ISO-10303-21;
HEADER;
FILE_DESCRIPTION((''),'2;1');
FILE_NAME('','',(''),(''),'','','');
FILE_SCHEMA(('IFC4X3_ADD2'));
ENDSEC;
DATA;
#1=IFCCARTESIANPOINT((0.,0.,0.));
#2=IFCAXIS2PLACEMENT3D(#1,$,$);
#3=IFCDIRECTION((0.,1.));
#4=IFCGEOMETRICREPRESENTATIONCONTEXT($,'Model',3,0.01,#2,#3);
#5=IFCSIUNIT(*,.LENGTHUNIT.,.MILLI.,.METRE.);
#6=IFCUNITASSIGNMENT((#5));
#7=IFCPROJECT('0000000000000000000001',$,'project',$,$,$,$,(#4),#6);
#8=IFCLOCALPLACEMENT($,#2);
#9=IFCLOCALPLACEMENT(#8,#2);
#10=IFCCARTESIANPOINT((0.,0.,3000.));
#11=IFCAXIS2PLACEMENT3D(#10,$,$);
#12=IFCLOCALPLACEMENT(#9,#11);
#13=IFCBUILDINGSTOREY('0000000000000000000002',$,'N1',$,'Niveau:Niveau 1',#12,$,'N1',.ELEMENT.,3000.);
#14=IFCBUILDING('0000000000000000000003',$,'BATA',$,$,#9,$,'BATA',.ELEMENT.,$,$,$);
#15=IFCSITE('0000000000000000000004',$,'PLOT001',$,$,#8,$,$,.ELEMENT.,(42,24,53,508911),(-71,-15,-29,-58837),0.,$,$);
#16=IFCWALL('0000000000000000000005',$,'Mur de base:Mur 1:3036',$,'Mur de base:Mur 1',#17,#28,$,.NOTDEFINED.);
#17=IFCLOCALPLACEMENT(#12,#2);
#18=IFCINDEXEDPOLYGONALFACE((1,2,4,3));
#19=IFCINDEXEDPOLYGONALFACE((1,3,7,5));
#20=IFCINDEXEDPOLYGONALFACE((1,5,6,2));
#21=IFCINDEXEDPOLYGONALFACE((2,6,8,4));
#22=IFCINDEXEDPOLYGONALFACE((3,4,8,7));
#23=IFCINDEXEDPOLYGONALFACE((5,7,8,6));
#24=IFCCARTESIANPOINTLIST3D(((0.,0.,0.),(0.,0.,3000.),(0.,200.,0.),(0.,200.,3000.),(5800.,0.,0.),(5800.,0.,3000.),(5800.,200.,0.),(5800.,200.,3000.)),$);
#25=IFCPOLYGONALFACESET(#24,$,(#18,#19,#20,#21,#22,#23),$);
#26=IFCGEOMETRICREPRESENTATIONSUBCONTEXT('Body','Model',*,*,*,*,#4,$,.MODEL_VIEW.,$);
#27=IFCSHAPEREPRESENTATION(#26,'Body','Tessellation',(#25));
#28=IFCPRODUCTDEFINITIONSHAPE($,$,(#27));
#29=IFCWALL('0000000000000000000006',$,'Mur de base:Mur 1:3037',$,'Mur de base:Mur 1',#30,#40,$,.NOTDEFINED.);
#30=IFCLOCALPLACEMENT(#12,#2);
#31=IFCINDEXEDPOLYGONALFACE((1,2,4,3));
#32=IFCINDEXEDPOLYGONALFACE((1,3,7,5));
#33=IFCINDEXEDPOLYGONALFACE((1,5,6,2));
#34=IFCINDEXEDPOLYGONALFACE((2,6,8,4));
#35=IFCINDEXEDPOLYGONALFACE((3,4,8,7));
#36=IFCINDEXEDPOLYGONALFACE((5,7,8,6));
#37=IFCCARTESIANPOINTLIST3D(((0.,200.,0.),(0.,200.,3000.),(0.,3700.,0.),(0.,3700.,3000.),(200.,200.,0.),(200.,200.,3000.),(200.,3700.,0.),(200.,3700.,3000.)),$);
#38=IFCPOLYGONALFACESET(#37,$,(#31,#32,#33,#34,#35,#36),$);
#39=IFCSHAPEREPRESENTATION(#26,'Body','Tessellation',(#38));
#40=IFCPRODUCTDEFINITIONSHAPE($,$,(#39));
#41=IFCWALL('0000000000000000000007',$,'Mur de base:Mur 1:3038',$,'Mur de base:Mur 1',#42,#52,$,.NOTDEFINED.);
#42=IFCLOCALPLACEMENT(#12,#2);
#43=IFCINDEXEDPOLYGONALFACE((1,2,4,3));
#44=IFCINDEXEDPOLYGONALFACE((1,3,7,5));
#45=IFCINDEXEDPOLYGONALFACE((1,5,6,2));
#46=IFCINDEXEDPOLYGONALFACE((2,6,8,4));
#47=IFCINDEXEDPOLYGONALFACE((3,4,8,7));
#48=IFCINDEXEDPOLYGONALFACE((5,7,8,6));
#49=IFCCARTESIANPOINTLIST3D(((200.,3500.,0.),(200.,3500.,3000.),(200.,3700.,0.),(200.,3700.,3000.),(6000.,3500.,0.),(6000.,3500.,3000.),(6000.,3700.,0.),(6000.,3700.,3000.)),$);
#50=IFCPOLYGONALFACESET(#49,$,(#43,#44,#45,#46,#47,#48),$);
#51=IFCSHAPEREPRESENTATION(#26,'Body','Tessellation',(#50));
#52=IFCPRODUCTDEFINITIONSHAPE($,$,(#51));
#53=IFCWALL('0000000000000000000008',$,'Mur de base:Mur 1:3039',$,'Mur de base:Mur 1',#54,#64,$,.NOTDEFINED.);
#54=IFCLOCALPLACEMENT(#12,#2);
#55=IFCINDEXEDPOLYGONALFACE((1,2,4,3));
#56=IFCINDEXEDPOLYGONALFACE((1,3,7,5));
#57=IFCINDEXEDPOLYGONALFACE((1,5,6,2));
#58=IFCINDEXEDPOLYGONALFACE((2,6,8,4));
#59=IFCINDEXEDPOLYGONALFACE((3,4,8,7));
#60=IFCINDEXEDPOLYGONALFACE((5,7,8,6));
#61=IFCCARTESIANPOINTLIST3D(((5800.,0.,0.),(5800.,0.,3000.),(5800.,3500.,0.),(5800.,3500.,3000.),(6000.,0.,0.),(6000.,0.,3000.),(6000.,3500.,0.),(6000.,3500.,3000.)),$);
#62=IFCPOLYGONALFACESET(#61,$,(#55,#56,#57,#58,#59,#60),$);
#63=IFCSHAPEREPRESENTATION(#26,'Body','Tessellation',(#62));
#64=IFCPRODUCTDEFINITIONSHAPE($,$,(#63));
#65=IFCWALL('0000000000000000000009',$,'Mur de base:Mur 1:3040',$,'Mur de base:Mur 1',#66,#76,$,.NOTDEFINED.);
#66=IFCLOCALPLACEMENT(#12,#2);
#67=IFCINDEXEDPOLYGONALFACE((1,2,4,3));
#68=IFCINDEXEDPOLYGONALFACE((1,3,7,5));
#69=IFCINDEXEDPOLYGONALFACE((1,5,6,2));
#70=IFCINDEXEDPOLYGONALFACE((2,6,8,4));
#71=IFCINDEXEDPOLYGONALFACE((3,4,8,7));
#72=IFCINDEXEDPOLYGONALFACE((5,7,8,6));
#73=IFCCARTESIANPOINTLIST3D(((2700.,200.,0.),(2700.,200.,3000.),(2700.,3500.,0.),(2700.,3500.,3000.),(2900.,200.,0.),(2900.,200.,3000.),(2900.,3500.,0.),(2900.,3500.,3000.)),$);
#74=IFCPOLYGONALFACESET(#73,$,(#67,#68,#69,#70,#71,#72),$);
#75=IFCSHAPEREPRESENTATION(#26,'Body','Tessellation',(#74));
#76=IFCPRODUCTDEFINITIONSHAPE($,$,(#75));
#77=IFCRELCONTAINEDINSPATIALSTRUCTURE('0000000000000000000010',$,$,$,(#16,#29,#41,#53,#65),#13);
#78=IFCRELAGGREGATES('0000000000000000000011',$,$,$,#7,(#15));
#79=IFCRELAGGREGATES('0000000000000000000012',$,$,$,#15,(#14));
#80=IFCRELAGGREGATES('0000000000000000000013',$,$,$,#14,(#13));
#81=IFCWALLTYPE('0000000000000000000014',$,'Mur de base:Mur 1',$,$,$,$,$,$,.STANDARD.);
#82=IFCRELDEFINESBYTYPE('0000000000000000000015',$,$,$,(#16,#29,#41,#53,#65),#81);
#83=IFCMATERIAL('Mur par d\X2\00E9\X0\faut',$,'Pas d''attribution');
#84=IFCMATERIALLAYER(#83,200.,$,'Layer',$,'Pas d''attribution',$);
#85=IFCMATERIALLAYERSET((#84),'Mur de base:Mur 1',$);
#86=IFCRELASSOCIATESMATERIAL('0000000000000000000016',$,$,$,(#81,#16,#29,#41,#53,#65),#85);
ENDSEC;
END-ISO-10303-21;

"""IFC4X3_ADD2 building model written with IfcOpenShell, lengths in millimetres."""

from ifc_helpers import new_model, si_unit, direction, frame, frame_2d, origin, place, context, subcontext, project, spatial, rectangle, extrude, material, layer, layer_set, type_object, element, save


model = new_model("IFC4X3_ADD2")

# Units and contexts
model_context = context("Model", 3, precision=0.01, world=origin(), true_north=direction((0.0, 1.0)))
body_context = subcontext(model_context, "Body", "Model", "MODEL_VIEW")
ifc_project = project(units=[si_unit("LENGTHUNIT", "METRE", prefix="MILLI")], contexts=[model_context])

# Site, building, storey
site_placement = place(None, origin())
site = spatial("IfcSite", under=ifc_project, at=site_placement, Name="PLOT001", CompositionType="ELEMENT", RefLatitude=(42, 24, 53, 508911), RefLongitude=(-71, -15, -29, -58837), RefElevation=0.0)
building_placement = place(site_placement, origin())
building = spatial("IfcBuilding", under=site, at=building_placement, Name="BATA", LongName="BATA", CompositionType="ELEMENT")
storey_placement = place(building_placement, frame((0.0, 0.0, 3000.0)))
storey = spatial("IfcBuildingStorey", under=building, at=storey_placement, Name="N1", ObjectType="Niveau:Niveau 1", LongName="N1", CompositionType="ELEMENT", Elevation=3000.0)

# Walls
ifc_material = material(Name="Mur par défaut", Category="Pas d'attribution")
ifc_layer = layer(ifc_material, 200.0, Name="Layer", Category="Pas d'attribution")
ifc_layer_set = layer_set([ifc_layer], Name="Mur de base:Mur 1")
wall_type = type_object("IfcWallType", Name="Mur de base:Mur 1", PredefinedType="STANDARD", material=ifc_layer_set)
wall_1_placement = place(storey_placement, frame((0.0, 100.0, 0.0)))
element("IfcWall", 1, at=wall_1_placement, inside=storey, type_object=wall_type, material=ifc_layer_set, Name="Mur de base:Mur 1:3036", ObjectType="Mur de base:Mur 1", PredefinedType="NOTDEFINED", context=body_context, shape_type="SweptSolid", body=[
    extrude(rectangle(XDim=5800.0, YDim=200.0, at=frame_2d((2900.0, 0.0), x_axis=(-1.0, 0.0))), origin(), (0.0, 0.0, 1.0), 3000.0),
])
wall_2_placement = place(storey_placement, frame((100.0, 3700.0, 0.0), z_axis=(0.0, 0.0, 1.0), x_axis=(0.0, -1.0, 0.0)))
element("IfcWall", 2, at=wall_2_placement, inside=storey, type_object=wall_type, material=ifc_layer_set, Name="Mur de base:Mur 1:3037", ObjectType="Mur de base:Mur 1", PredefinedType="NOTDEFINED", context=body_context, shape_type="SweptSolid", body=[
    extrude(rectangle(XDim=3500.0, YDim=200.0, at=frame_2d((1750.0, 0.0), x_axis=(-1.0, 0.0))), origin(), (0.0, 0.0, 1.0), 3000.0),
])
wall_3_placement = place(storey_placement, frame((6000.0, 3600.0, 0.0), z_axis=(0.0, 0.0, 1.0), x_axis=(-1.0, 0.0, 0.0)))
element("IfcWall", 3, at=wall_3_placement, inside=storey, type_object=wall_type, material=ifc_layer_set, Name="Mur de base:Mur 1:3038", ObjectType="Mur de base:Mur 1", PredefinedType="NOTDEFINED", context=body_context, shape_type="SweptSolid", body=[
    extrude(rectangle(XDim=5800.0, YDim=200.0, at=frame_2d((2900.0, 0.0), x_axis=(-1.0, 0.0))), origin(), (0.0, 0.0, 1.0), 3000.0),
])
wall_4_placement = place(storey_placement, frame((5900.0, 0.0, 0.0), z_axis=(0.0, 0.0, 1.0), x_axis=(0.0, 1.0, 0.0)))
element("IfcWall", 4, at=wall_4_placement, inside=storey, type_object=wall_type, material=ifc_layer_set, Name="Mur de base:Mur 1:3039", ObjectType="Mur de base:Mur 1", PredefinedType="NOTDEFINED", context=body_context, shape_type="SweptSolid", body=[
    extrude(rectangle(XDim=3500.0, YDim=200.0, at=frame_2d((1750.0, 0.0), x_axis=(-1.0, 0.0))), origin(), (0.0, 0.0, 1.0), 3000.0),
])
wall_5_placement = place(storey_placement, frame((2800.0, 200.0, 0.0), z_axis=(0.0, 0.0, 1.0), x_axis=(0.0, 1.0, 0.0)))
element("IfcWall", 5, at=wall_5_placement, inside=storey, type_object=wall_type, material=ifc_layer_set, Name="Mur de base:Mur 1:3040", ObjectType="Mur de base:Mur 1", PredefinedType="NOTDEFINED", context=body_context, shape_type="SweptSolid", body=[
    extrude(rectangle(XDim=3300.0, YDim=200.0, at=frame_2d((1650.0, 0.0), x_axis=(-1.0, 0.0))), origin(), (0.0, 0.0, 1.0), 3000.0),
])

save(model, "model.ifc")
